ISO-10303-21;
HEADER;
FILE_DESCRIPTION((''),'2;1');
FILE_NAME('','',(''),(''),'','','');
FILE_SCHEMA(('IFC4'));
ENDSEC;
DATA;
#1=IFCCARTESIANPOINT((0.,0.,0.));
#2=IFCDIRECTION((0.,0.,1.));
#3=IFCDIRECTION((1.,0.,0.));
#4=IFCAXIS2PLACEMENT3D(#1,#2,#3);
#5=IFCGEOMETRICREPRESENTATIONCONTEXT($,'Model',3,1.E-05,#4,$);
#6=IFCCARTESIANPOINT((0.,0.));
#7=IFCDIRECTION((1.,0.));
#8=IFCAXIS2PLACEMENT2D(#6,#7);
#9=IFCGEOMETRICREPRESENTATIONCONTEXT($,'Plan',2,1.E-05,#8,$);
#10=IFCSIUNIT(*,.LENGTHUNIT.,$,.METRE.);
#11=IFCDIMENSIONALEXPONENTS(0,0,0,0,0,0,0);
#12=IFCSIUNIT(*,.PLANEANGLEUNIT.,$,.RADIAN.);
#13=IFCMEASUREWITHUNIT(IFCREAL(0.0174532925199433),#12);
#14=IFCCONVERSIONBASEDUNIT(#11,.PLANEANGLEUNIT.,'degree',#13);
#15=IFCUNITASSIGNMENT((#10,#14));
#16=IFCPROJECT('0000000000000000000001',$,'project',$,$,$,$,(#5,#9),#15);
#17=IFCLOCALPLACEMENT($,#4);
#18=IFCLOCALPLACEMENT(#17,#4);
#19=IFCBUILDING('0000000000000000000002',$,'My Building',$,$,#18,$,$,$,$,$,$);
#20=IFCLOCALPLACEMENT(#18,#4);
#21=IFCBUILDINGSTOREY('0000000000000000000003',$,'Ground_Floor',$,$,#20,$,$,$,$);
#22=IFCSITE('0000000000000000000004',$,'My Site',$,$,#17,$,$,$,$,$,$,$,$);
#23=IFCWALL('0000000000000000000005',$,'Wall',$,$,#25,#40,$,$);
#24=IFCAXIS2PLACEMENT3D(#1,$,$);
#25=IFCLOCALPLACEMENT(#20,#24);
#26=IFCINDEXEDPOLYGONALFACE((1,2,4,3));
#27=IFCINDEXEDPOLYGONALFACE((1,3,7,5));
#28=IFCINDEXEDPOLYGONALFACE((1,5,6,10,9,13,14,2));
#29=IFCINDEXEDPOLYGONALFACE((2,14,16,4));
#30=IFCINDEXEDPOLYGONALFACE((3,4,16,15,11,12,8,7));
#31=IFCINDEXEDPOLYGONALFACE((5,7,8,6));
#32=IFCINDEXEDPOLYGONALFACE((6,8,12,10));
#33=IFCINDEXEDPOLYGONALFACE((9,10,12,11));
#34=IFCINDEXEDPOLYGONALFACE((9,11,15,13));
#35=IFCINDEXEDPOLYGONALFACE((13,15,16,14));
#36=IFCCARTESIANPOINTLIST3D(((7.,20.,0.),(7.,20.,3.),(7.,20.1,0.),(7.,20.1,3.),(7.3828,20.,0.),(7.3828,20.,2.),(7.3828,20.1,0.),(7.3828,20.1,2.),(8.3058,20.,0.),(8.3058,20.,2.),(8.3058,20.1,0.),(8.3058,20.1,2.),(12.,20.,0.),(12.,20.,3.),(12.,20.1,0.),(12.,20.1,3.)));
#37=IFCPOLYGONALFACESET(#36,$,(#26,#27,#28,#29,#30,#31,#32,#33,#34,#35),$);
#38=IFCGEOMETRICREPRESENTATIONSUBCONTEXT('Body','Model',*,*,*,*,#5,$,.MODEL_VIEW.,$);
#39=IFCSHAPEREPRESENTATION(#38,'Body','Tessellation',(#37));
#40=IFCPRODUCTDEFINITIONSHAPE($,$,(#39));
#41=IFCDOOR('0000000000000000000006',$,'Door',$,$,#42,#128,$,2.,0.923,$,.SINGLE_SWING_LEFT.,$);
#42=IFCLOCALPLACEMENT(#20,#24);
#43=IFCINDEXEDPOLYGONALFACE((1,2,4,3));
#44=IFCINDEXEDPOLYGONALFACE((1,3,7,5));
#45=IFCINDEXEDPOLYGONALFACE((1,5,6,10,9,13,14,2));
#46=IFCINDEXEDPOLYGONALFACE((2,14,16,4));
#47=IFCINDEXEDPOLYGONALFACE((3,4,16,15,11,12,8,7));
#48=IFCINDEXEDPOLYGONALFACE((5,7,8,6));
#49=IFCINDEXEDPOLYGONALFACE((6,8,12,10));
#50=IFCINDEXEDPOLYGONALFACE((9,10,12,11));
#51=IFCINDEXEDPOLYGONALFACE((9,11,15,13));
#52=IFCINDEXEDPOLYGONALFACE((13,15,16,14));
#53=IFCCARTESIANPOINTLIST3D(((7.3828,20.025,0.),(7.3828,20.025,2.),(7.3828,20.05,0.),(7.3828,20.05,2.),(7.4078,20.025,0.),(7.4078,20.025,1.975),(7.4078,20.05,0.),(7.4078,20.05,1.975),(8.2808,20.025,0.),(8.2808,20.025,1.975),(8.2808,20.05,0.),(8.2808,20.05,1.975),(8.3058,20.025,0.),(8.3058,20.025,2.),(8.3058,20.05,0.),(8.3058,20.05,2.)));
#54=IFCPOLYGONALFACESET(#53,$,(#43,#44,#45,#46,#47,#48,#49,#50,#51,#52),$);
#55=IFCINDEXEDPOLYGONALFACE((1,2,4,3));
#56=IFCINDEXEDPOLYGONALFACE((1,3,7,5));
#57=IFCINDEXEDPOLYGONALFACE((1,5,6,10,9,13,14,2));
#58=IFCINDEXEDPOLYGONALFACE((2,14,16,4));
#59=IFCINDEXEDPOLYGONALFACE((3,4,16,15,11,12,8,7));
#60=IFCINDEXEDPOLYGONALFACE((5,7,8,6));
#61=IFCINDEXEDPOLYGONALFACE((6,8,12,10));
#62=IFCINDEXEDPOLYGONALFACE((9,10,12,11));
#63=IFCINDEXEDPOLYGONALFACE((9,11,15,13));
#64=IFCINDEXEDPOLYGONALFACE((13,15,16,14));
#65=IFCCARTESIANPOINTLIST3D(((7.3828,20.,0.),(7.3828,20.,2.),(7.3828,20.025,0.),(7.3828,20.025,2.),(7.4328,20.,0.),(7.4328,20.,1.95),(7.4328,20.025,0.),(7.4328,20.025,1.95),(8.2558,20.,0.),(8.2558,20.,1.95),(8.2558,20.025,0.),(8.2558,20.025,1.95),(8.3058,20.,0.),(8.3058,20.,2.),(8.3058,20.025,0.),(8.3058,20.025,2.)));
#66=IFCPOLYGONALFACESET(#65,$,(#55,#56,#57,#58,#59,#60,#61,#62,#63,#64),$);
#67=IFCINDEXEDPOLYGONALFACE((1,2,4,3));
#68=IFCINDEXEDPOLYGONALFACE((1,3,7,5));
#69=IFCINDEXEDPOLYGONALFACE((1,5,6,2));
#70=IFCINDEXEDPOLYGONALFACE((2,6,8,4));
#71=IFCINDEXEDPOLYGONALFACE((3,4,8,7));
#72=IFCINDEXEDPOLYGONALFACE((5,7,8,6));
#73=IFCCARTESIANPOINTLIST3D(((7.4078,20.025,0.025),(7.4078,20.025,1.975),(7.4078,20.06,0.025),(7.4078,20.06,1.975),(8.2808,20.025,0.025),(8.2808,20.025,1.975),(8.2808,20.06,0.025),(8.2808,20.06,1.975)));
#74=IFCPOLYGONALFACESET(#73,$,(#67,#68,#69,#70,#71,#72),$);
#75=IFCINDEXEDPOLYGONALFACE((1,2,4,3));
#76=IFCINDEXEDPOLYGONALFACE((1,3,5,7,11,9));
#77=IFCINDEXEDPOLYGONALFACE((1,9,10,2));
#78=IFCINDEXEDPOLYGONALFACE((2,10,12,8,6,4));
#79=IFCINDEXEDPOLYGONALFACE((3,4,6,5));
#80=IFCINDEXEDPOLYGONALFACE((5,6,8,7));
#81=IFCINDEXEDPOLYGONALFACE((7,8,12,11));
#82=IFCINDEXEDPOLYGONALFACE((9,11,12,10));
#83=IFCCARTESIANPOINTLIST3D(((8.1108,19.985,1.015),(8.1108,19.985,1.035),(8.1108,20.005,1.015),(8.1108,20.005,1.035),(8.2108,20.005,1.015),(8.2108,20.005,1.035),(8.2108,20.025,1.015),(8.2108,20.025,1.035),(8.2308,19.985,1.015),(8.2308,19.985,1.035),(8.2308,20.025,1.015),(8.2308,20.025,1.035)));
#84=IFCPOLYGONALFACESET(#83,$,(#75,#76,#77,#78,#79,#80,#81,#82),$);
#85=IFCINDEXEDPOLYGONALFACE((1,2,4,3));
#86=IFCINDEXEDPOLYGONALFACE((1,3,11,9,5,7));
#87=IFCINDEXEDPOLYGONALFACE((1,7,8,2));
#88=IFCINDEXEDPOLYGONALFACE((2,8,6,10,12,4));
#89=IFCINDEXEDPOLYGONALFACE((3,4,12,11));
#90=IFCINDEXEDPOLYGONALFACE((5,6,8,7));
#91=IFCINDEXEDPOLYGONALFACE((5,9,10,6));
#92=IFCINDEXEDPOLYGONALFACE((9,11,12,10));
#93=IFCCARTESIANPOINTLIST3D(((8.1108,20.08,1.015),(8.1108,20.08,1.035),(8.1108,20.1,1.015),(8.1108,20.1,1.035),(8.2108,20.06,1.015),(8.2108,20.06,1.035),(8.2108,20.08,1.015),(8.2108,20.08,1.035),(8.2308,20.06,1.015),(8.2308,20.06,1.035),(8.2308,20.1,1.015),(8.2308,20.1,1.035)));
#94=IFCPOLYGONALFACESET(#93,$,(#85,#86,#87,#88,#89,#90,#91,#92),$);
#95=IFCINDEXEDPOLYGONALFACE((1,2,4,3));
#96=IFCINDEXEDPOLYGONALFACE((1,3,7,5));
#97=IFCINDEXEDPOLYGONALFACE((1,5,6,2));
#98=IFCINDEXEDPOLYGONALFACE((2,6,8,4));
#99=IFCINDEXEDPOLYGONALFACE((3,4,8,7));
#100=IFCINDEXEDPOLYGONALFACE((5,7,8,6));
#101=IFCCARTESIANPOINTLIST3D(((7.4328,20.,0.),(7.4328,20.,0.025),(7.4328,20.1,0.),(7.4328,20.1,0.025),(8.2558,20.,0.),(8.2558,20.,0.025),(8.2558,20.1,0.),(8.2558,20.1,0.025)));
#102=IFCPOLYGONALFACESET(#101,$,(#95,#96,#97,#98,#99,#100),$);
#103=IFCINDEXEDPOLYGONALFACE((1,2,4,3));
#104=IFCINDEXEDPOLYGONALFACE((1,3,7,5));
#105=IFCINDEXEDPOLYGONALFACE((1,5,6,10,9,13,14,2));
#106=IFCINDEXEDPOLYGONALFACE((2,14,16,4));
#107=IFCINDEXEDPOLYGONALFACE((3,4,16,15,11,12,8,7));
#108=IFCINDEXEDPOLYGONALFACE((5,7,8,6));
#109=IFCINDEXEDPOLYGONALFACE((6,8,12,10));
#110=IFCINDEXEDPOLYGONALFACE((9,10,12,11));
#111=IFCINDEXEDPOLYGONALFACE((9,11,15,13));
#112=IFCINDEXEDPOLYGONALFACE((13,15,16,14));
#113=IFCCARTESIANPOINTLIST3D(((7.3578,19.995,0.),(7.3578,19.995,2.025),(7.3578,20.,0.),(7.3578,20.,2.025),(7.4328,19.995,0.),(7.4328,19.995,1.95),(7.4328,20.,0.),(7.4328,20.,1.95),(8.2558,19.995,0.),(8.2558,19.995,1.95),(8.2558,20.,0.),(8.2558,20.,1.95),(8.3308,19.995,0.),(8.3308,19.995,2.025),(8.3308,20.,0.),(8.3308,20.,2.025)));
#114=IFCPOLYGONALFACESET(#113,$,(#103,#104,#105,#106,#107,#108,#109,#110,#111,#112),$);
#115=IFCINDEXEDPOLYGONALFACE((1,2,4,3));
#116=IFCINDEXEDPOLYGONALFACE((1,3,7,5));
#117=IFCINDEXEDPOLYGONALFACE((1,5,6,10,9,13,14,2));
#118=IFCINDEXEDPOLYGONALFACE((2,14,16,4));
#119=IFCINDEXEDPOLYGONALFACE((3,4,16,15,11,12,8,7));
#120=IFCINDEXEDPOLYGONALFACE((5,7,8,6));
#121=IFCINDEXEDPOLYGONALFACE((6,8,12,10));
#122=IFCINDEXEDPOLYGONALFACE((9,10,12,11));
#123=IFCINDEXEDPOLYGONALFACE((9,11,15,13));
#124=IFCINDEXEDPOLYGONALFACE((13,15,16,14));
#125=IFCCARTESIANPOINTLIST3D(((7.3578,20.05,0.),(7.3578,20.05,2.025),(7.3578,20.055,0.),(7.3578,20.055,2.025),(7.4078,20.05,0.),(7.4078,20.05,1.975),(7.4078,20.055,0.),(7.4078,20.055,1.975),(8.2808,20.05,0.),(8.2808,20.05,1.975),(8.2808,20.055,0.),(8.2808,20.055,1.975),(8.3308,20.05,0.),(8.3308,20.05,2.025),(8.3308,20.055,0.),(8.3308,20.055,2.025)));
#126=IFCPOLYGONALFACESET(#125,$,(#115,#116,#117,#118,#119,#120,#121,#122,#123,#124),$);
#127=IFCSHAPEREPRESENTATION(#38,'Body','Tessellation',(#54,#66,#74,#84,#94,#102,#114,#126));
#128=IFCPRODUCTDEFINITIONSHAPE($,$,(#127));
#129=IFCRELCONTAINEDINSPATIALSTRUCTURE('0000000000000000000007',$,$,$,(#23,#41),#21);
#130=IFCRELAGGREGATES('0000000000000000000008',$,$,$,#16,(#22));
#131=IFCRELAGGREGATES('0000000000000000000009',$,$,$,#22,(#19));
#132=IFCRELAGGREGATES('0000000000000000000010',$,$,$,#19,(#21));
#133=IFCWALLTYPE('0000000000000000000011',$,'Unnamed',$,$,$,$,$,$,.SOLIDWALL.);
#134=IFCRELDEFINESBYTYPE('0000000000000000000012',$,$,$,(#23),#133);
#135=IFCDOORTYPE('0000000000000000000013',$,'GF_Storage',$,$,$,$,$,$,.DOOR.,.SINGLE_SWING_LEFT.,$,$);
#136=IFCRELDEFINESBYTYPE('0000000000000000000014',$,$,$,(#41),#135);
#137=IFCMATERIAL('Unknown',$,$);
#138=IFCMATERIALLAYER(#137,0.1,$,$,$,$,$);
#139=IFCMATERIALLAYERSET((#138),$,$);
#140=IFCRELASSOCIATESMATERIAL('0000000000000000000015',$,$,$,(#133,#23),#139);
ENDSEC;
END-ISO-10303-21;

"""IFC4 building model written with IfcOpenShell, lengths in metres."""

from ifc_helpers import new_model, entity, si_unit, converted_unit, frame, origin_with_axes, origin_2d_with_axis, place, context, subcontext, project, spatial, line, indexed_curve, outline, extrude, shape, source, transform, mapped, material, layer, layer_set, layer_usage, type_object, type_shapes, element, fill, save


model = new_model("IFC4")

# Units and contexts
model_context = context("Model", 3, precision=1e-05, world=origin_with_axes())
plan_context = context("Plan", 2, precision=1e-05, world=origin_2d_with_axis())
body_context_1 = subcontext(model_context, "Body", "Model", "MODEL_VIEW")
body_context_2 = subcontext(plan_context, "Body", "Plan", "PLAN_VIEW")
ifc_project = project(units=[si_unit("LENGTHUNIT", "METRE"), converted_unit("PLANEANGLEUNIT", "degree", entity("IfcReal", 0.0174532925199433), si_unit("PLANEANGLEUNIT", "RADIAN"), dimensions=[0, 0, 0, 0, 0, 0, 0])], contexts=[model_context, plan_context])

# Site, building, storey
site_placement = place(None, origin_with_axes())
site = spatial("IfcSite", under=ifc_project, at=site_placement, Name="My Site")
building_placement = place(site_placement, origin_with_axes())
building = spatial("IfcBuilding", under=site, at=building_placement, Name="My Building")
storey_placement = place(building_placement, origin_with_axes())
storey = spatial("IfcBuildingStorey", under=building, at=storey_placement, Name="Ground_Floor")

# Shared definitions
ifc_material = material(Name="Unknown")

# Shared definitions
ifc_layer_1 = layer(ifc_material, 0.1)
ifc_layer_set_1 = layer_set([ifc_layer_1])
wall_type = type_object("IfcWallType", Name="Unnamed", PredefinedType="SOLIDWALL", material=ifc_layer_set_1)
shared_shape_1 = source(origin_with_axes(), body_context_1, "Body", "SweptSolid", [
    extrude(outline(indexed_curve([(0.0, 0.0), (0.923, 0.0), (0.923, 2.0), (0.0, 2.0)], segments=[line(1, 2, 3, 4, 1)])), frame((0.0, -0.6, 0.0), z_axis=(0.0, -1.0, 0.0), x_axis=(1.0, 0.0, 0.0)), (0.0, 0.0, -1.0), 1.2),
])
door_type_1 = type_object("IfcDoorType", Name="GF_Storage", OperationType="SINGLE_SWING_LEFT", PredefinedType="DOOR")
shared_shape_2 = source(origin_with_axes(), body_context_1, "Body", "SweptSolid", [
    extrude(outline(indexed_curve([(0.0, 0.0), (0.0, 2.0), (0.923, 2.0), (0.923, 0.0), (0.898, 0.0), (0.898, 1.975), (0.025, 1.975), (0.025, 0.0)], segments=[line(1, 2, 3, 4, 5, 6, 7, 8, 1)])), frame((0.0, 0.025, 0.0), z_axis=(0.0, -1.0, 0.0), x_axis=(1.0, 0.0, 0.0)), (0.0, 0.0, -1.0), 0.025),
    extrude(outline(indexed_curve([(0.0, 0.0), (0.0, 2.0), (0.923, 2.0), (0.923, 0.0), (0.873, 0.0), (0.873, 1.95), (0.05, 1.95), (0.05, 0.0)], segments=[line(1, 2, 3, 4, 5, 6, 7, 8, 1)])), frame((0.0, 0.0, 0.0), z_axis=(0.0, -1.0, 0.0), x_axis=(1.0, 0.0, 0.0)), (0.0, 0.0, -1.0), 0.025),
    extrude(outline(indexed_curve([(0.0, 0.0), (0.873, 0.0), (0.873, 0.035), (0.0, 0.035)], segments=[line(1, 2, 3, 4, 1)])), frame((0.025, 0.025, 0.025), z_axis=(0.0, 0.0, 1.0), x_axis=(1.0, 0.0, 0.0)), (0.0, 0.0, 1.0), 1.95),
    extrude(outline(indexed_curve([(0.0, 0.0), (0.0, -0.04), (-0.12, -0.04), (-0.12, -0.02), (-0.02, -0.02), (-0.02, 0.0)], segments=[line(1, 2, 3, 4, 5, 6, 1)])), frame((0.848, 0.025, 1.015), z_axis=(0.0, 0.0, 1.0), x_axis=(1.0, 0.0, 0.0)), (0.0, 0.0, 1.0), 0.02),
    extrude(outline(indexed_curve([(0.0, 0.0), (0.0, 0.04), (-0.12, 0.04), (-0.12, 0.02), (-0.02, 0.02), (-0.02, 0.0)], segments=[line(1, 2, 3, 4, 5, 6, 1)])), frame((0.848, 0.06, 1.015), z_axis=(0.0, 0.0, 1.0), x_axis=(1.0, 0.0, 0.0)), (0.0, 0.0, 1.0), 0.02),
    extrude(outline(indexed_curve([(0.0, 0.0), (0.823, 0.0), (0.823, 0.1), (0.0, 0.1)], segments=[line(1, 2, 3, 4, 1)])), frame((0.05, 0.0, 0.0), z_axis=(0.0, 0.0, 1.0), x_axis=(1.0, 0.0, 0.0)), (0.0, 0.0, 1.0), 0.025),
    extrude(outline(indexed_curve([(0.0, 0.0), (0.0, 2.025), (0.973, 2.025), (0.973, 0.0), (0.898, 0.0), (0.898, 1.95), (0.075, 1.95), (0.075, 0.0)], segments=[line(1, 2, 3, 4, 5, 6, 7, 8, 1)])), frame((-0.025, -0.005, 0.0), z_axis=(0.0, -1.0, 0.0), x_axis=(1.0, 0.0, 0.0)), (0.0, 0.0, -1.0), 0.005),
    extrude(outline(indexed_curve([(0.0, 0.0), (0.0, 2.025), (0.973, 2.025), (0.973, 0.0), (0.923, 0.0), (0.923, 1.975), (0.05, 1.975), (0.05, 0.0)], segments=[line(1, 2, 3, 4, 5, 6, 7, 8, 1)])), frame((-0.025, 0.05, 0.0), z_axis=(0.0, -1.0, 0.0), x_axis=(1.0, 0.0, 0.0)), (0.0, 0.0, -1.0), 0.005),
])
shared_shape_3 = source(origin_with_axes(), body_context_2, "Body", "Curve2D", [
    entity("IfcIndexedPolyCurve", entity("IfcCartesianPointList2D", [[0.0, 0.0], [0.0, 0.05], [0.025, 0.05], [0.025, 0.025], [0.05, 0.025], [0.05, 0.0]]), [entity("IfcLineIndex", [1, 2, 3, 4, 5, 6, 1])]),
    entity("IfcIndexedPolyCurve", entity("IfcCartesianPointList2D", [[0.923, 0.0], [0.923, 0.05], [0.898, 0.05], [0.898, 0.025], [0.873, 0.025], [0.873, 0.0]]), [entity("IfcLineIndex", [1, 2, 3, 4, 5, 6, 1])]),
    entity("IfcTrimmedCurve", entity("IfcEllipse", entity("IfcAxis2Placement2D", entity("IfcCartesianPoint", [0.06, 0.05]), entity("IfcDirection", [1.0, 0.0])), 0.838, 0.873), [entity("IfcCartesianPoint", [0.898, 0.05])], [entity("IfcCartesianPoint", [0.06, 0.923])], True, "CARTESIAN"),
    entity("IfcIndexedPolyCurve", entity("IfcCartesianPointList2D", [[0.025, 0.05], [0.06, 0.05], [0.06, 0.923], [0.025, 0.923]]), [entity("IfcLineIndex", [1, 2, 3, 4, 1])]),
])
type_shapes(door_type_1, [shared_shape_2, shared_shape_3])

# Wall, opening, door
ifc_layer_usage_1 = layer_usage(ifc_layer_set_1, "AXIS2", "POSITIVE", 0.0)
wall_1_placement = place(storey_placement, frame((7.0, 20.0, 0.0), z_axis=(0.0, 0.0, 1.0), x_axis=(1.0, 0.0, 0.0)))
wall_1 = element("IfcWall", 1, at=wall_1_placement, inside=storey, type_object=wall_type, material=ifc_layer_usage_1, Name="Wall", context=body_context_1, shape_type="SweptSolid", body=[
    extrude(outline(indexed_curve([(0.0, 0.0), (0.0, 0.1), (5.0, 0.1), (5.0, 0.0)], segments=[line(1, 2, 3, 4, 1)])), origin_with_axes(), (0.0, 0.0, 1.0), 3.0),
])
opening_1_placement = place(wall_1_placement, frame((0.3828, 0.0, 0.0), z_axis=(0.0, 0.0, 1.0), x_axis=(1.0, 0.0, 0.0)))
opening_1 = element("IfcOpeningElement", 2, at=opening_1_placement, cuts=wall_1, PredefinedType="OPENING", context=body_context_1, shape_type="MappedRepresentation", body=[
    mapped(shared_shape_1, transform((0.0, 0.0, 0.0), x_axis=(1.0, 0.0, 0.0), y_axis=(0.0, 1.0, 0.0), z_axis=(0.0, 0.0, 1.0), scale=1.0)),
])
placement_1 = place(storey_placement, frame((7.0, 20.0, 0.0), z_axis=(0.0, 0.0, 1.0), x_axis=(1.0, 0.0, 0.0)))
placement_2 = place(placement_1, frame((0.3828, 0.0, 0.0), z_axis=(0.0, 0.0, 1.0), x_axis=(1.0, 0.0, 0.0)))
door_1_placement = place(placement_2, origin_with_axes())
door_1 = element("IfcDoor", 3, at=door_1_placement, inside=storey, type_object=door_type_1, Name="Door", OperationType="SINGLE_SWING_LEFT", OverallHeight=2.0, OverallWidth=0.923, shapes=[
    shape(body_context_1, "Body", "MappedRepresentation", [mapped(shared_shape_2, transform((0.0, 0.0, 0.0), x_axis=(1.0, 0.0, 0.0), y_axis=(0.0, 1.0, 0.0), z_axis=(0.0, 0.0, 1.0), scale=1.0))]),
    shape(body_context_2, "Body", "MappedRepresentation", [mapped(shared_shape_3, transform((0.0, 0.0, 0.0), x_axis=(1.0, 0.0, 0.0), y_axis=(0.0, 1.0, 0.0), z_axis=(0.0, 0.0, 1.0), scale=1.0))]),
])
fill(opening_1, door_1)

save(model, "model.ifc")
